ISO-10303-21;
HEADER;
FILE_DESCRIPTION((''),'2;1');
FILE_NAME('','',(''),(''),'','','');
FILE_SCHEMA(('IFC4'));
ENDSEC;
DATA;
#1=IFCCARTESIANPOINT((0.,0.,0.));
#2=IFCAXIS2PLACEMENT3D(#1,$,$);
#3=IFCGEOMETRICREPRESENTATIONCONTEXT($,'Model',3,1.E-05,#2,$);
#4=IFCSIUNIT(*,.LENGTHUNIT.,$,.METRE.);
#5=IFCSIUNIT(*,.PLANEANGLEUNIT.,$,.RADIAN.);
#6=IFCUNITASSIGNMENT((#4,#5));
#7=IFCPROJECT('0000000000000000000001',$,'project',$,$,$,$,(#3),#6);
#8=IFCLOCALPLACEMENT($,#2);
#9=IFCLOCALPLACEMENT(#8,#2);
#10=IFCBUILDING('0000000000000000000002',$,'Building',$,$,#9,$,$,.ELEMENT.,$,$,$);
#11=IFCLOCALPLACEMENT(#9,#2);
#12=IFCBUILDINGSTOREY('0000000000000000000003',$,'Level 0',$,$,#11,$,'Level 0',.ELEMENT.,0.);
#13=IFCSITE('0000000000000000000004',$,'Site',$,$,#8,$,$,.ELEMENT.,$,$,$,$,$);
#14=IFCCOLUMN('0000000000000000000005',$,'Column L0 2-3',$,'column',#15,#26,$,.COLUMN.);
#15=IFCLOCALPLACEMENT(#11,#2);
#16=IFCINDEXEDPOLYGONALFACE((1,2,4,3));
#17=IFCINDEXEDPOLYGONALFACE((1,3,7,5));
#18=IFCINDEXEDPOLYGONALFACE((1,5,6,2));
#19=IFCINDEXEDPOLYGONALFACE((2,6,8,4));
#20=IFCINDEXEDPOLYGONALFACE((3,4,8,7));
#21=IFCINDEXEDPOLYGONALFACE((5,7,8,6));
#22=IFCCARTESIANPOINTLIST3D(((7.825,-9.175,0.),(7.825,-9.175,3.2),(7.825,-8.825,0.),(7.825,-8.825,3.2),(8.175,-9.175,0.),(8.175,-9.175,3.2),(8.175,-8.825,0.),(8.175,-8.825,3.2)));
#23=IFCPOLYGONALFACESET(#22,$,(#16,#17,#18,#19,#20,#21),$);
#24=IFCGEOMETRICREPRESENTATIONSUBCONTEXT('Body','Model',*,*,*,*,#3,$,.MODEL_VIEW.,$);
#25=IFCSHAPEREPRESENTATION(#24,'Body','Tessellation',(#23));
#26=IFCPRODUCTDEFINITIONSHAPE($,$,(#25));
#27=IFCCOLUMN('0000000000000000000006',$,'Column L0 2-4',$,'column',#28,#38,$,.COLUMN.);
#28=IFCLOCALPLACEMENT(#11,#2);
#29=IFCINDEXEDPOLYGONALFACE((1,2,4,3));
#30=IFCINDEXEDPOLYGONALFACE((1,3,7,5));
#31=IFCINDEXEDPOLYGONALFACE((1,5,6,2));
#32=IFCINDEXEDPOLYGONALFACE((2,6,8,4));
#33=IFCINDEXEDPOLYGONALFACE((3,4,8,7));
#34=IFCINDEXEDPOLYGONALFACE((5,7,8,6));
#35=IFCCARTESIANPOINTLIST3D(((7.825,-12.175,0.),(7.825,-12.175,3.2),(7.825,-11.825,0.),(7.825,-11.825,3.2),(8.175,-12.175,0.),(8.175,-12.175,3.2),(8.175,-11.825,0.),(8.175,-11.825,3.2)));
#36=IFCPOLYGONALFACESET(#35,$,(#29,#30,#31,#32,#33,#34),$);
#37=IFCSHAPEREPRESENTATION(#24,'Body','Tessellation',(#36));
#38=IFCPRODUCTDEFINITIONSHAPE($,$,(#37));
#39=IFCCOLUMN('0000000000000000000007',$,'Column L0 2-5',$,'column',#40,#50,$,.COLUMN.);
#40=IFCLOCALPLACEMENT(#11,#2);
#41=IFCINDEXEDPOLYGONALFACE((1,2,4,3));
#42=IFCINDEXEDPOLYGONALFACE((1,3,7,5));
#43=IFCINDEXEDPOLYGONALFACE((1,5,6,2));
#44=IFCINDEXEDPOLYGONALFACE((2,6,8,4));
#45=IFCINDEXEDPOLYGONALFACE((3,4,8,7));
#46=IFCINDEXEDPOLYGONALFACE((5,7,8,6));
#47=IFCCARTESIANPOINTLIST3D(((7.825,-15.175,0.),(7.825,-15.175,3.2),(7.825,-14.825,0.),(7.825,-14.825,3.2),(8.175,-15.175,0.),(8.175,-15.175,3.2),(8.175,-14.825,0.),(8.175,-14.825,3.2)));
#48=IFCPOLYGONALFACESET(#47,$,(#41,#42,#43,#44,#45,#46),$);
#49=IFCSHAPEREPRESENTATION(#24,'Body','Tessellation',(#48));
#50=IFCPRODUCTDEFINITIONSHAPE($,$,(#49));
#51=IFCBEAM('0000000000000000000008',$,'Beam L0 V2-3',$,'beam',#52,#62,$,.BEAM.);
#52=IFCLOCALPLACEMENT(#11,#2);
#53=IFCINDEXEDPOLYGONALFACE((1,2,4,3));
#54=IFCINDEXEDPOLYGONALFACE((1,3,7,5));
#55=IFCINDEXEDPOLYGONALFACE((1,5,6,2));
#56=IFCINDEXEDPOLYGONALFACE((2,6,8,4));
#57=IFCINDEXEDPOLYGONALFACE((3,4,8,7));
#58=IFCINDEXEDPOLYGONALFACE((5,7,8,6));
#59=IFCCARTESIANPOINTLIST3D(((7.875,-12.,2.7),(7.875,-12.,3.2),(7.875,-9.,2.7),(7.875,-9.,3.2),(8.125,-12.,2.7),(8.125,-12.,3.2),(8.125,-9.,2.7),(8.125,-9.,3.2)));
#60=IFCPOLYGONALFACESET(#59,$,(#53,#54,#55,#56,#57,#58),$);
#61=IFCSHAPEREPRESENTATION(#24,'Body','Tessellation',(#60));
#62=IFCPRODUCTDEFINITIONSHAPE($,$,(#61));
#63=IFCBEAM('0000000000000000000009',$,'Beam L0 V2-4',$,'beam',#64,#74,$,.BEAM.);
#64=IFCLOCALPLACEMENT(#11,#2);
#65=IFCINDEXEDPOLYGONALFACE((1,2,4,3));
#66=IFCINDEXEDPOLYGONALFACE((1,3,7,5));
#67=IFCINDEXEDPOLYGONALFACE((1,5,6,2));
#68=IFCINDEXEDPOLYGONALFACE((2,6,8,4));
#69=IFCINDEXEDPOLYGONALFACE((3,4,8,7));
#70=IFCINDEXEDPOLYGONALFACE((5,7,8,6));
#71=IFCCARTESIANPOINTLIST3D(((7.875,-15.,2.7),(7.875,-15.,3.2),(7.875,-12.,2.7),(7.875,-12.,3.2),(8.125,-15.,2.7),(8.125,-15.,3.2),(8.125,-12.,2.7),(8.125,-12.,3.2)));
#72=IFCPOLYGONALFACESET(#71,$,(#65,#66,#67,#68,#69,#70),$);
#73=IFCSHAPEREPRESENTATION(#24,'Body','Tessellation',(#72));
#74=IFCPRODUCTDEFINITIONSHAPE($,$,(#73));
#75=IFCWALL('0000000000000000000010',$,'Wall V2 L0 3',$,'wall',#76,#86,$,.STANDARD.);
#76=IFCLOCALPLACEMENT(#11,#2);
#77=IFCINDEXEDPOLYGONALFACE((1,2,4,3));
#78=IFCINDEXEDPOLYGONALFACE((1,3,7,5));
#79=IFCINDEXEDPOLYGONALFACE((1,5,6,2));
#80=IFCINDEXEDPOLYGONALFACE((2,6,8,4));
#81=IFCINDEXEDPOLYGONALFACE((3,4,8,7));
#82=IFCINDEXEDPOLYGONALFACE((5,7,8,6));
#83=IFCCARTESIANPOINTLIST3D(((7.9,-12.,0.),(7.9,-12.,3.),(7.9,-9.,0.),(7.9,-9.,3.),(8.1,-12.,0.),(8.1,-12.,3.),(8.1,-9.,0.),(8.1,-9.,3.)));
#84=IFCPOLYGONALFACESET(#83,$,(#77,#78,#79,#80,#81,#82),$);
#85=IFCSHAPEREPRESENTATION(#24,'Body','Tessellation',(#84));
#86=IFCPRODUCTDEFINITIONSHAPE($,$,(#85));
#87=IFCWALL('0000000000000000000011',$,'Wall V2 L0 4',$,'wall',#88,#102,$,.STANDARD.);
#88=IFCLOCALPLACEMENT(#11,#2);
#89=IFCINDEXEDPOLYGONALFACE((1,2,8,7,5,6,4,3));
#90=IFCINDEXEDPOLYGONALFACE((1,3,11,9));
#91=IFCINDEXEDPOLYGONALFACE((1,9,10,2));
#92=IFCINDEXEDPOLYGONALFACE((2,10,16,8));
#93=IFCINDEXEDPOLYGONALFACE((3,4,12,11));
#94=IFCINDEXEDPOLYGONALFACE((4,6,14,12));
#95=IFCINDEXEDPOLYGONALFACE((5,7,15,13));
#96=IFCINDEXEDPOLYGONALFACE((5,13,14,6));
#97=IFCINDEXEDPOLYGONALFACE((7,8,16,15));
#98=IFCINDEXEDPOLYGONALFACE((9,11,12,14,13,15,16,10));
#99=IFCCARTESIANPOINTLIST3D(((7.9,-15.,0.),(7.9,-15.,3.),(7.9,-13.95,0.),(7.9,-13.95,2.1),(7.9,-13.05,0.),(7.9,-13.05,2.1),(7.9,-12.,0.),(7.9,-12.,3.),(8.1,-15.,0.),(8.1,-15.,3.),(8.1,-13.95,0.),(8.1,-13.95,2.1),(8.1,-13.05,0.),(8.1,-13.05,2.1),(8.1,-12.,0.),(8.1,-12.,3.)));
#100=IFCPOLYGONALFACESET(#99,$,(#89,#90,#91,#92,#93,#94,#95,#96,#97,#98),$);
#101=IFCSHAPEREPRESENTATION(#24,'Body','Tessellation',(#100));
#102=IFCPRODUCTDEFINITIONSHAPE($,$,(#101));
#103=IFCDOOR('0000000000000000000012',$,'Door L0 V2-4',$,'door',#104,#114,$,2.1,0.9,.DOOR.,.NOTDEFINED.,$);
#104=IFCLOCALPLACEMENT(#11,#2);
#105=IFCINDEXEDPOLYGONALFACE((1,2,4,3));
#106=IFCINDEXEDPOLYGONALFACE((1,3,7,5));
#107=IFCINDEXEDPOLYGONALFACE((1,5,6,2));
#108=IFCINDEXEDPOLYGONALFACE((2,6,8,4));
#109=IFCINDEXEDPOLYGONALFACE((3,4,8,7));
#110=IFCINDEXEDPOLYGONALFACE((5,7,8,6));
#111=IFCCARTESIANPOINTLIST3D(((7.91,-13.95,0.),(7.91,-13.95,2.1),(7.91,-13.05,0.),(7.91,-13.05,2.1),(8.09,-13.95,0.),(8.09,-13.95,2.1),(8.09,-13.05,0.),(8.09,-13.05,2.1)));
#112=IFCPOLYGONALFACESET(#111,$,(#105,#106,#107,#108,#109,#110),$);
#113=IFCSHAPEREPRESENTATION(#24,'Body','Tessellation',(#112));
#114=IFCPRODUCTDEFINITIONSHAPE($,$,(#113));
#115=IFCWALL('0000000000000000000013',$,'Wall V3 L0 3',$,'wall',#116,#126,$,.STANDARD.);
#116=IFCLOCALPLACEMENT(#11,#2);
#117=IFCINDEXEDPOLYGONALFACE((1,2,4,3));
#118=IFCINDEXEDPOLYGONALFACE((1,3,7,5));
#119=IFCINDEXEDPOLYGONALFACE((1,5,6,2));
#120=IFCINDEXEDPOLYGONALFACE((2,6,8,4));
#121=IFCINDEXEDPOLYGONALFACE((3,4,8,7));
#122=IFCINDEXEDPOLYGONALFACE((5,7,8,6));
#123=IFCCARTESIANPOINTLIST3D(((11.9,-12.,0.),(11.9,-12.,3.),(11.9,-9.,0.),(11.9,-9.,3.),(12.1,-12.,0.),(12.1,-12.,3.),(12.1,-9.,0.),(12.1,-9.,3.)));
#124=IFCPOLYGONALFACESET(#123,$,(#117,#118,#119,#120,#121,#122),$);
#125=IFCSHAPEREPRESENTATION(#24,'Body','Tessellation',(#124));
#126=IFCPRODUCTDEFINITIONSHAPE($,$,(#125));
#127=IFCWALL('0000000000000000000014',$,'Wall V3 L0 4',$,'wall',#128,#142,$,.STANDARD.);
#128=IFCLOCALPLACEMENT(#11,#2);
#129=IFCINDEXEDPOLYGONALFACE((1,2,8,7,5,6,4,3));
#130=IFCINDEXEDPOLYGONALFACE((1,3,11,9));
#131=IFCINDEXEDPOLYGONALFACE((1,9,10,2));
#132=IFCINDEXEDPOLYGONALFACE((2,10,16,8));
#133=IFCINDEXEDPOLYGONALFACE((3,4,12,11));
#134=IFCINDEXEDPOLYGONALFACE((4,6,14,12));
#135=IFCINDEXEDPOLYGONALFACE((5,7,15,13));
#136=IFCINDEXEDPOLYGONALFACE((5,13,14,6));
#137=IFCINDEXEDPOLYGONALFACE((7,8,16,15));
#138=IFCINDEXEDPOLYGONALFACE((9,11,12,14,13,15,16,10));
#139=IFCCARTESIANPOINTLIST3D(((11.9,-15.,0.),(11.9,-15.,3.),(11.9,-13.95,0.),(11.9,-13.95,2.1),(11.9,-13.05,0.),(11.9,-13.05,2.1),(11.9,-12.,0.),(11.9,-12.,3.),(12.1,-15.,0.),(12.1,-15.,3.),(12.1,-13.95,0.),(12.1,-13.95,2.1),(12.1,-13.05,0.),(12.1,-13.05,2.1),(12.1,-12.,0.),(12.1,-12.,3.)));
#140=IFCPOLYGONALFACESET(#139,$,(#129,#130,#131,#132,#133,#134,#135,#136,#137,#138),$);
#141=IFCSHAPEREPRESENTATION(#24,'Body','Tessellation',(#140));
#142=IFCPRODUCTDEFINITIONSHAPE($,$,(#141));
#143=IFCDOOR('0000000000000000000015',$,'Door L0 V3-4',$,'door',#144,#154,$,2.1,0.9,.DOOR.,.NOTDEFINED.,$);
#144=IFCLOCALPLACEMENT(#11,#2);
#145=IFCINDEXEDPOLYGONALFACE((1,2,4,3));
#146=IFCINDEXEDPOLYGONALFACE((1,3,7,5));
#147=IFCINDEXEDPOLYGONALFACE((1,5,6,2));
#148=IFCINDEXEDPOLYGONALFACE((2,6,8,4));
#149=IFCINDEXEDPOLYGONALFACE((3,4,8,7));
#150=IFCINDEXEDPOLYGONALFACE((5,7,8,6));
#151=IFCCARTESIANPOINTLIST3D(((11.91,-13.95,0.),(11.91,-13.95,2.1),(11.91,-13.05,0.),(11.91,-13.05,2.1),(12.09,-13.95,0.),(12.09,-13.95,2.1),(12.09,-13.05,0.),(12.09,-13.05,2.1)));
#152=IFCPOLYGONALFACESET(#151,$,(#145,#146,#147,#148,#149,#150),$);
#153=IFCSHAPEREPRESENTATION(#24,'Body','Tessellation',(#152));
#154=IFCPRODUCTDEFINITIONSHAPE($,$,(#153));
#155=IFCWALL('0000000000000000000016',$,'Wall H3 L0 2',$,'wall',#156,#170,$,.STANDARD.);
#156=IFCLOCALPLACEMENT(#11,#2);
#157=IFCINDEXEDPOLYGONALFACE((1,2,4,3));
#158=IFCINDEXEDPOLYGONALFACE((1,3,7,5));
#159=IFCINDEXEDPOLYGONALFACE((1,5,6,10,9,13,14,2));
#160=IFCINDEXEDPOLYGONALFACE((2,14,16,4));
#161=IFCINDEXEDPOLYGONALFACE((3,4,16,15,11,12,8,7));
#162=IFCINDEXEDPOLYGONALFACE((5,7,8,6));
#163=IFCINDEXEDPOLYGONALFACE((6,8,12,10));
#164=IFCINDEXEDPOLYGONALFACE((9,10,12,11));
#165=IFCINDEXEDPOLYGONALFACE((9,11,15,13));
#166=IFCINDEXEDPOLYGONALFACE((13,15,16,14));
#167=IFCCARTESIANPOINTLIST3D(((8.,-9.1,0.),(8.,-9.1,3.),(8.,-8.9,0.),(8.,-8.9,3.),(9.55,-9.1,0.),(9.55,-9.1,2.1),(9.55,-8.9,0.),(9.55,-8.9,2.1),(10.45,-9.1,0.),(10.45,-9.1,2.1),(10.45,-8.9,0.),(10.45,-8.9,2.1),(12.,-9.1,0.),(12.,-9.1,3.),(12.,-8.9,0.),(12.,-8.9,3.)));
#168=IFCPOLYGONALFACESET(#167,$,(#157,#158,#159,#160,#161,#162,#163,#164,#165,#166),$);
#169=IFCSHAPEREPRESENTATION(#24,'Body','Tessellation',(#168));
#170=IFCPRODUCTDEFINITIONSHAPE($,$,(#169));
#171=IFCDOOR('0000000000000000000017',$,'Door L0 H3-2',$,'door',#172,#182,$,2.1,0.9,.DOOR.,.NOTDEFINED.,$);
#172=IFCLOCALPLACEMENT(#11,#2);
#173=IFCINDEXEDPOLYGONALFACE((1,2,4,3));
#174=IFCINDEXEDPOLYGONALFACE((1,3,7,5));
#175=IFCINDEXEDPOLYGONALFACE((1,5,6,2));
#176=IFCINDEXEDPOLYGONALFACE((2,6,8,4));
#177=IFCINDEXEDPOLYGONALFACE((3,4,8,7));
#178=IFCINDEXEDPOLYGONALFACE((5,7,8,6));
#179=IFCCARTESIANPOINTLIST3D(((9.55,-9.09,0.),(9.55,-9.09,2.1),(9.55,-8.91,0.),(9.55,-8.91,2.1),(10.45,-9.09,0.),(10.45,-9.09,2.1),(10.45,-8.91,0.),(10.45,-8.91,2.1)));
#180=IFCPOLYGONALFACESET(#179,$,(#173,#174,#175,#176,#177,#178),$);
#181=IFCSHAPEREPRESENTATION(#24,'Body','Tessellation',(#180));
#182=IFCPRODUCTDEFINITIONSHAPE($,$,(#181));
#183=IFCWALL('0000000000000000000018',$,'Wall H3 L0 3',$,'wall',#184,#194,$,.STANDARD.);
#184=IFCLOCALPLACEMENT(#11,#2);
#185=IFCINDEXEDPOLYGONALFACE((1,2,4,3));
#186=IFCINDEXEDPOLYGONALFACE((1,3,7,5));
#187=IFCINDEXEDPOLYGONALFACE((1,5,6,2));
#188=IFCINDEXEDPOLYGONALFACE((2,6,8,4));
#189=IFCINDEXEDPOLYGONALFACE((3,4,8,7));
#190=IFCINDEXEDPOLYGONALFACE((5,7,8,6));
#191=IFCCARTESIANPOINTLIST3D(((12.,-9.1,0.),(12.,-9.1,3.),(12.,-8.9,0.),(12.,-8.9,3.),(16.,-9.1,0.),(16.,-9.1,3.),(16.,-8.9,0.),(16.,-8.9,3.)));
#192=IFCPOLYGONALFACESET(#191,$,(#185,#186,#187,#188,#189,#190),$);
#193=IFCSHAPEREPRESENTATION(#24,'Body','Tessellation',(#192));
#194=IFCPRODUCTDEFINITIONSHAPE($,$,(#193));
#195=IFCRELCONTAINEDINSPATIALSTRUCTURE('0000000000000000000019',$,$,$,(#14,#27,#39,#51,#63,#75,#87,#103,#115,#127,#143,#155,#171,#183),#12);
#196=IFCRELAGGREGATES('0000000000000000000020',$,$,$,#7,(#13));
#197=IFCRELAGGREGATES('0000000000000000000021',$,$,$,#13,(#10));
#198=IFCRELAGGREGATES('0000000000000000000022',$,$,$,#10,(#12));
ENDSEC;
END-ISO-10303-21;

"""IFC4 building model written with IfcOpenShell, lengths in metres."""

from ifc_helpers import new_model, si_unit, frame, frame_2d, origin, origin_2d, place, context, subcontext, project, spatial, rectangle, extrude, element, fill, save


model = new_model("IFC4")

# Units and contexts
model_context = context("Model", 3, precision=1e-05, world=origin())
body_context = subcontext(model_context, "Body", "Model", "MODEL_VIEW")
ifc_project = project(units=[si_unit("LENGTHUNIT", "METRE"), si_unit("PLANEANGLEUNIT", "RADIAN")], contexts=[model_context])

# Site, building, storey
site_placement = place(None, origin())
site = spatial("IfcSite", under=ifc_project, at=site_placement, Name="Site", CompositionType="ELEMENT")
building_placement = place(site_placement, origin())
building = spatial("IfcBuilding", under=site, at=building_placement, Name="Building", CompositionType="ELEMENT")
storey_placement = place(building_placement, origin())
storey = spatial("IfcBuildingStorey", under=building, at=storey_placement, Name="Level 0", LongName="Level 0", CompositionType="ELEMENT", Elevation=0.0)

# Columns
for number, where, name in (
    (1, (8.0, -9.0, 0.0), "Column L0 2-3"),
    (2, (8.0, -12.0, 0.0), "Column L0 2-4"),
    (3, (8.0, -15.0, 0.0), "Column L0 2-5"),
):
    element("IfcColumn", number, at=place(storey_placement, frame(where)), inside=storey, Name=name, ObjectType="column", PredefinedType="COLUMN", context=body_context, shape_type="SweptSolid", body=[
        extrude(rectangle(XDim=0.35, YDim=0.35, at=origin_2d()), origin(), (0.0, 0.0, 1.0), 3.2),
    ])

# Beams
for number, where, z_axis, x_axis, name in (
    (4, (8.0, -9.0, 2.95), (0.0, -1.0, 0.0), (0.0, 0.0, 1.0), "Beam L0 V2-3"),
    (5, (8.0, -12.0, 2.95), (0.0, -1.0, 0.0), (0.0, 0.0, 1.0), "Beam L0 V2-4"),
):
    element("IfcBeam", number, at=place(storey_placement, frame(where, z_axis=z_axis, x_axis=x_axis)), inside=storey, Name=name, ObjectType="beam", PredefinedType="BEAM", context=body_context, shape_type="SweptSolid", body=[
        extrude(rectangle(XDim=0.5, YDim=0.25, at=origin_2d()), origin(), (0.0, 0.0, 1.0), 3.0),
    ])

# Wall
wall_1_placement = place(storey_placement, frame((8.0, -9.0, 0.0), z_axis=(0.0, 0.0, 1.0), x_axis=(0.0, -1.0, 0.0)))
element("IfcWall", 6, at=wall_1_placement, inside=storey, Name="Wall V2 L0 3", ObjectType="wall", PredefinedType="STANDARD", context=body_context, shape_type="SweptSolid", body=[
    extrude(rectangle(XDim=3.0, YDim=0.2, at=frame_2d((1.5, 0.0))), origin(), (0.0, 0.0, 1.0), 3.0),
])

# Wall, opening, door
wall_2_placement = place(storey_placement, frame((8.0, -12.0, 0.0), z_axis=(0.0, 0.0, 1.0), x_axis=(0.0, -1.0, 0.0)))
wall_2 = element("IfcWall", 7, at=wall_2_placement, inside=storey, Name="Wall V2 L0 4", ObjectType="wall", PredefinedType="STANDARD", context=body_context, shape_type="SweptSolid", body=[
    extrude(rectangle(XDim=3.0, YDim=0.2, at=frame_2d((1.5, 0.0))), origin(), (0.0, 0.0, 1.0), 3.0),
])
opening_1_placement = place(storey_placement, frame((8.0, -13.5, 0.0), z_axis=(0.0, 0.0, 1.0), x_axis=(0.0, -1.0, 0.0)))
opening_1 = element("IfcOpeningElement", 8, at=opening_1_placement, cuts=wall_2, ObjectType="Opening", PredefinedType="OPENING", context=body_context, shape_type="SweptSolid", body=[
    extrude(rectangle(XDim=0.9, YDim=0.22, at=origin_2d()), origin(), (0.0, 0.0, 1.0), 2.1),
])
door_1_placement = place(storey_placement, frame((8.0, -13.5, 0.0), z_axis=(0.0, 0.0, 1.0), x_axis=(0.0, -1.0, 0.0)))
door_1 = element("IfcDoor", 9, at=door_1_placement, inside=storey, Name="Door L0 V2-4", ObjectType="door", OperationType="NOTDEFINED", OverallHeight=2.1, OverallWidth=0.9, PredefinedType="DOOR", context=body_context, shape_type="SweptSolid", body=[
    extrude(rectangle(XDim=0.9, YDim=0.18, at=origin_2d()), origin(), (0.0, 0.0, 1.0), 2.1),
])
fill(opening_1, door_1)

# Wall
wall_3_placement = place(storey_placement, frame((12.0, -9.0, 0.0), z_axis=(0.0, 0.0, 1.0), x_axis=(0.0, -1.0, 0.0)))
element("IfcWall", 10, at=wall_3_placement, inside=storey, Name="Wall V3 L0 3", ObjectType="wall", PredefinedType="STANDARD", context=body_context, shape_type="SweptSolid", body=[
    extrude(rectangle(XDim=3.0, YDim=0.2, at=frame_2d((1.5, 0.0))), origin(), (0.0, 0.0, 1.0), 3.0),
])

# Walls, openings, doors
wall_4_placement = place(storey_placement, frame((12.0, -12.0, 0.0), z_axis=(0.0, 0.0, 1.0), x_axis=(0.0, -1.0, 0.0)))
wall_4 = element("IfcWall", 11, at=wall_4_placement, inside=storey, Name="Wall V3 L0 4", ObjectType="wall", PredefinedType="STANDARD", context=body_context, shape_type="SweptSolid", body=[
    extrude(rectangle(XDim=3.0, YDim=0.2, at=frame_2d((1.5, 0.0))), origin(), (0.0, 0.0, 1.0), 3.0),
])
opening_2_placement = place(storey_placement, frame((12.0, -13.5, 0.0), z_axis=(0.0, 0.0, 1.0), x_axis=(0.0, -1.0, 0.0)))
opening_2 = element("IfcOpeningElement", 12, at=opening_2_placement, cuts=wall_4, ObjectType="Opening", PredefinedType="OPENING", context=body_context, shape_type="SweptSolid", body=[
    extrude(rectangle(XDim=0.9, YDim=0.22, at=origin_2d()), origin(), (0.0, 0.0, 1.0), 2.1),
])
door_2_placement = place(storey_placement, frame((12.0, -13.5, 0.0), z_axis=(0.0, 0.0, 1.0), x_axis=(0.0, -1.0, 0.0)))
door_2 = element("IfcDoor", 13, at=door_2_placement, inside=storey, Name="Door L0 V3-4", ObjectType="door", OperationType="NOTDEFINED", OverallHeight=2.1, OverallWidth=0.9, PredefinedType="DOOR", context=body_context, shape_type="SweptSolid", body=[
    extrude(rectangle(XDim=0.9, YDim=0.18, at=origin_2d()), origin(), (0.0, 0.0, 1.0), 2.1),
])
fill(opening_2, door_2)
wall_5_placement = place(storey_placement, frame((8.0, -9.0, 0.0), z_axis=(0.0, 0.0, 1.0), x_axis=(1.0, 0.0, 0.0)))
wall_5 = element("IfcWall", 14, at=wall_5_placement, inside=storey, Name="Wall H3 L0 2", ObjectType="wall", PredefinedType="STANDARD", context=body_context, shape_type="SweptSolid", body=[
    extrude(rectangle(XDim=4.0, YDim=0.2, at=frame_2d((2.0, 0.0))), origin(), (0.0, 0.0, 1.0), 3.0),
])
opening_3_placement = place(storey_placement, frame((10.0, -9.0, 0.0), z_axis=(0.0, 0.0, 1.0), x_axis=(1.0, 0.0, 0.0)))
opening_3 = element("IfcOpeningElement", 15, at=opening_3_placement, cuts=wall_5, ObjectType="Opening", PredefinedType="OPENING", context=body_context, shape_type="SweptSolid", body=[
    extrude(rectangle(XDim=0.9, YDim=0.22, at=origin_2d()), origin(), (0.0, 0.0, 1.0), 2.1),
])
door_3_placement = place(storey_placement, frame((10.0, -9.0, 0.0), z_axis=(0.0, 0.0, 1.0), x_axis=(1.0, 0.0, 0.0)))
door_3 = element("IfcDoor", 16, at=door_3_placement, inside=storey, Name="Door L0 H3-2", ObjectType="door", OperationType="NOTDEFINED", OverallHeight=2.1, OverallWidth=0.9, PredefinedType="DOOR", context=body_context, shape_type="SweptSolid", body=[
    extrude(rectangle(XDim=0.9, YDim=0.18, at=origin_2d()), origin(), (0.0, 0.0, 1.0), 2.1),
])
fill(opening_3, door_3)

# Wall
wall_6_placement = place(storey_placement, frame((12.0, -9.0, 0.0), z_axis=(0.0, 0.0, 1.0), x_axis=(1.0, 0.0, 0.0)))
element("IfcWall", 17, at=wall_6_placement, inside=storey, Name="Wall H3 L0 3", ObjectType="wall", PredefinedType="STANDARD", context=body_context, shape_type="SweptSolid", body=[
    extrude(rectangle(XDim=4.0, YDim=0.2, at=frame_2d((2.0, 0.0))), origin(), (0.0, 0.0, 1.0), 3.0),
])

save(model, "model.ifc")
